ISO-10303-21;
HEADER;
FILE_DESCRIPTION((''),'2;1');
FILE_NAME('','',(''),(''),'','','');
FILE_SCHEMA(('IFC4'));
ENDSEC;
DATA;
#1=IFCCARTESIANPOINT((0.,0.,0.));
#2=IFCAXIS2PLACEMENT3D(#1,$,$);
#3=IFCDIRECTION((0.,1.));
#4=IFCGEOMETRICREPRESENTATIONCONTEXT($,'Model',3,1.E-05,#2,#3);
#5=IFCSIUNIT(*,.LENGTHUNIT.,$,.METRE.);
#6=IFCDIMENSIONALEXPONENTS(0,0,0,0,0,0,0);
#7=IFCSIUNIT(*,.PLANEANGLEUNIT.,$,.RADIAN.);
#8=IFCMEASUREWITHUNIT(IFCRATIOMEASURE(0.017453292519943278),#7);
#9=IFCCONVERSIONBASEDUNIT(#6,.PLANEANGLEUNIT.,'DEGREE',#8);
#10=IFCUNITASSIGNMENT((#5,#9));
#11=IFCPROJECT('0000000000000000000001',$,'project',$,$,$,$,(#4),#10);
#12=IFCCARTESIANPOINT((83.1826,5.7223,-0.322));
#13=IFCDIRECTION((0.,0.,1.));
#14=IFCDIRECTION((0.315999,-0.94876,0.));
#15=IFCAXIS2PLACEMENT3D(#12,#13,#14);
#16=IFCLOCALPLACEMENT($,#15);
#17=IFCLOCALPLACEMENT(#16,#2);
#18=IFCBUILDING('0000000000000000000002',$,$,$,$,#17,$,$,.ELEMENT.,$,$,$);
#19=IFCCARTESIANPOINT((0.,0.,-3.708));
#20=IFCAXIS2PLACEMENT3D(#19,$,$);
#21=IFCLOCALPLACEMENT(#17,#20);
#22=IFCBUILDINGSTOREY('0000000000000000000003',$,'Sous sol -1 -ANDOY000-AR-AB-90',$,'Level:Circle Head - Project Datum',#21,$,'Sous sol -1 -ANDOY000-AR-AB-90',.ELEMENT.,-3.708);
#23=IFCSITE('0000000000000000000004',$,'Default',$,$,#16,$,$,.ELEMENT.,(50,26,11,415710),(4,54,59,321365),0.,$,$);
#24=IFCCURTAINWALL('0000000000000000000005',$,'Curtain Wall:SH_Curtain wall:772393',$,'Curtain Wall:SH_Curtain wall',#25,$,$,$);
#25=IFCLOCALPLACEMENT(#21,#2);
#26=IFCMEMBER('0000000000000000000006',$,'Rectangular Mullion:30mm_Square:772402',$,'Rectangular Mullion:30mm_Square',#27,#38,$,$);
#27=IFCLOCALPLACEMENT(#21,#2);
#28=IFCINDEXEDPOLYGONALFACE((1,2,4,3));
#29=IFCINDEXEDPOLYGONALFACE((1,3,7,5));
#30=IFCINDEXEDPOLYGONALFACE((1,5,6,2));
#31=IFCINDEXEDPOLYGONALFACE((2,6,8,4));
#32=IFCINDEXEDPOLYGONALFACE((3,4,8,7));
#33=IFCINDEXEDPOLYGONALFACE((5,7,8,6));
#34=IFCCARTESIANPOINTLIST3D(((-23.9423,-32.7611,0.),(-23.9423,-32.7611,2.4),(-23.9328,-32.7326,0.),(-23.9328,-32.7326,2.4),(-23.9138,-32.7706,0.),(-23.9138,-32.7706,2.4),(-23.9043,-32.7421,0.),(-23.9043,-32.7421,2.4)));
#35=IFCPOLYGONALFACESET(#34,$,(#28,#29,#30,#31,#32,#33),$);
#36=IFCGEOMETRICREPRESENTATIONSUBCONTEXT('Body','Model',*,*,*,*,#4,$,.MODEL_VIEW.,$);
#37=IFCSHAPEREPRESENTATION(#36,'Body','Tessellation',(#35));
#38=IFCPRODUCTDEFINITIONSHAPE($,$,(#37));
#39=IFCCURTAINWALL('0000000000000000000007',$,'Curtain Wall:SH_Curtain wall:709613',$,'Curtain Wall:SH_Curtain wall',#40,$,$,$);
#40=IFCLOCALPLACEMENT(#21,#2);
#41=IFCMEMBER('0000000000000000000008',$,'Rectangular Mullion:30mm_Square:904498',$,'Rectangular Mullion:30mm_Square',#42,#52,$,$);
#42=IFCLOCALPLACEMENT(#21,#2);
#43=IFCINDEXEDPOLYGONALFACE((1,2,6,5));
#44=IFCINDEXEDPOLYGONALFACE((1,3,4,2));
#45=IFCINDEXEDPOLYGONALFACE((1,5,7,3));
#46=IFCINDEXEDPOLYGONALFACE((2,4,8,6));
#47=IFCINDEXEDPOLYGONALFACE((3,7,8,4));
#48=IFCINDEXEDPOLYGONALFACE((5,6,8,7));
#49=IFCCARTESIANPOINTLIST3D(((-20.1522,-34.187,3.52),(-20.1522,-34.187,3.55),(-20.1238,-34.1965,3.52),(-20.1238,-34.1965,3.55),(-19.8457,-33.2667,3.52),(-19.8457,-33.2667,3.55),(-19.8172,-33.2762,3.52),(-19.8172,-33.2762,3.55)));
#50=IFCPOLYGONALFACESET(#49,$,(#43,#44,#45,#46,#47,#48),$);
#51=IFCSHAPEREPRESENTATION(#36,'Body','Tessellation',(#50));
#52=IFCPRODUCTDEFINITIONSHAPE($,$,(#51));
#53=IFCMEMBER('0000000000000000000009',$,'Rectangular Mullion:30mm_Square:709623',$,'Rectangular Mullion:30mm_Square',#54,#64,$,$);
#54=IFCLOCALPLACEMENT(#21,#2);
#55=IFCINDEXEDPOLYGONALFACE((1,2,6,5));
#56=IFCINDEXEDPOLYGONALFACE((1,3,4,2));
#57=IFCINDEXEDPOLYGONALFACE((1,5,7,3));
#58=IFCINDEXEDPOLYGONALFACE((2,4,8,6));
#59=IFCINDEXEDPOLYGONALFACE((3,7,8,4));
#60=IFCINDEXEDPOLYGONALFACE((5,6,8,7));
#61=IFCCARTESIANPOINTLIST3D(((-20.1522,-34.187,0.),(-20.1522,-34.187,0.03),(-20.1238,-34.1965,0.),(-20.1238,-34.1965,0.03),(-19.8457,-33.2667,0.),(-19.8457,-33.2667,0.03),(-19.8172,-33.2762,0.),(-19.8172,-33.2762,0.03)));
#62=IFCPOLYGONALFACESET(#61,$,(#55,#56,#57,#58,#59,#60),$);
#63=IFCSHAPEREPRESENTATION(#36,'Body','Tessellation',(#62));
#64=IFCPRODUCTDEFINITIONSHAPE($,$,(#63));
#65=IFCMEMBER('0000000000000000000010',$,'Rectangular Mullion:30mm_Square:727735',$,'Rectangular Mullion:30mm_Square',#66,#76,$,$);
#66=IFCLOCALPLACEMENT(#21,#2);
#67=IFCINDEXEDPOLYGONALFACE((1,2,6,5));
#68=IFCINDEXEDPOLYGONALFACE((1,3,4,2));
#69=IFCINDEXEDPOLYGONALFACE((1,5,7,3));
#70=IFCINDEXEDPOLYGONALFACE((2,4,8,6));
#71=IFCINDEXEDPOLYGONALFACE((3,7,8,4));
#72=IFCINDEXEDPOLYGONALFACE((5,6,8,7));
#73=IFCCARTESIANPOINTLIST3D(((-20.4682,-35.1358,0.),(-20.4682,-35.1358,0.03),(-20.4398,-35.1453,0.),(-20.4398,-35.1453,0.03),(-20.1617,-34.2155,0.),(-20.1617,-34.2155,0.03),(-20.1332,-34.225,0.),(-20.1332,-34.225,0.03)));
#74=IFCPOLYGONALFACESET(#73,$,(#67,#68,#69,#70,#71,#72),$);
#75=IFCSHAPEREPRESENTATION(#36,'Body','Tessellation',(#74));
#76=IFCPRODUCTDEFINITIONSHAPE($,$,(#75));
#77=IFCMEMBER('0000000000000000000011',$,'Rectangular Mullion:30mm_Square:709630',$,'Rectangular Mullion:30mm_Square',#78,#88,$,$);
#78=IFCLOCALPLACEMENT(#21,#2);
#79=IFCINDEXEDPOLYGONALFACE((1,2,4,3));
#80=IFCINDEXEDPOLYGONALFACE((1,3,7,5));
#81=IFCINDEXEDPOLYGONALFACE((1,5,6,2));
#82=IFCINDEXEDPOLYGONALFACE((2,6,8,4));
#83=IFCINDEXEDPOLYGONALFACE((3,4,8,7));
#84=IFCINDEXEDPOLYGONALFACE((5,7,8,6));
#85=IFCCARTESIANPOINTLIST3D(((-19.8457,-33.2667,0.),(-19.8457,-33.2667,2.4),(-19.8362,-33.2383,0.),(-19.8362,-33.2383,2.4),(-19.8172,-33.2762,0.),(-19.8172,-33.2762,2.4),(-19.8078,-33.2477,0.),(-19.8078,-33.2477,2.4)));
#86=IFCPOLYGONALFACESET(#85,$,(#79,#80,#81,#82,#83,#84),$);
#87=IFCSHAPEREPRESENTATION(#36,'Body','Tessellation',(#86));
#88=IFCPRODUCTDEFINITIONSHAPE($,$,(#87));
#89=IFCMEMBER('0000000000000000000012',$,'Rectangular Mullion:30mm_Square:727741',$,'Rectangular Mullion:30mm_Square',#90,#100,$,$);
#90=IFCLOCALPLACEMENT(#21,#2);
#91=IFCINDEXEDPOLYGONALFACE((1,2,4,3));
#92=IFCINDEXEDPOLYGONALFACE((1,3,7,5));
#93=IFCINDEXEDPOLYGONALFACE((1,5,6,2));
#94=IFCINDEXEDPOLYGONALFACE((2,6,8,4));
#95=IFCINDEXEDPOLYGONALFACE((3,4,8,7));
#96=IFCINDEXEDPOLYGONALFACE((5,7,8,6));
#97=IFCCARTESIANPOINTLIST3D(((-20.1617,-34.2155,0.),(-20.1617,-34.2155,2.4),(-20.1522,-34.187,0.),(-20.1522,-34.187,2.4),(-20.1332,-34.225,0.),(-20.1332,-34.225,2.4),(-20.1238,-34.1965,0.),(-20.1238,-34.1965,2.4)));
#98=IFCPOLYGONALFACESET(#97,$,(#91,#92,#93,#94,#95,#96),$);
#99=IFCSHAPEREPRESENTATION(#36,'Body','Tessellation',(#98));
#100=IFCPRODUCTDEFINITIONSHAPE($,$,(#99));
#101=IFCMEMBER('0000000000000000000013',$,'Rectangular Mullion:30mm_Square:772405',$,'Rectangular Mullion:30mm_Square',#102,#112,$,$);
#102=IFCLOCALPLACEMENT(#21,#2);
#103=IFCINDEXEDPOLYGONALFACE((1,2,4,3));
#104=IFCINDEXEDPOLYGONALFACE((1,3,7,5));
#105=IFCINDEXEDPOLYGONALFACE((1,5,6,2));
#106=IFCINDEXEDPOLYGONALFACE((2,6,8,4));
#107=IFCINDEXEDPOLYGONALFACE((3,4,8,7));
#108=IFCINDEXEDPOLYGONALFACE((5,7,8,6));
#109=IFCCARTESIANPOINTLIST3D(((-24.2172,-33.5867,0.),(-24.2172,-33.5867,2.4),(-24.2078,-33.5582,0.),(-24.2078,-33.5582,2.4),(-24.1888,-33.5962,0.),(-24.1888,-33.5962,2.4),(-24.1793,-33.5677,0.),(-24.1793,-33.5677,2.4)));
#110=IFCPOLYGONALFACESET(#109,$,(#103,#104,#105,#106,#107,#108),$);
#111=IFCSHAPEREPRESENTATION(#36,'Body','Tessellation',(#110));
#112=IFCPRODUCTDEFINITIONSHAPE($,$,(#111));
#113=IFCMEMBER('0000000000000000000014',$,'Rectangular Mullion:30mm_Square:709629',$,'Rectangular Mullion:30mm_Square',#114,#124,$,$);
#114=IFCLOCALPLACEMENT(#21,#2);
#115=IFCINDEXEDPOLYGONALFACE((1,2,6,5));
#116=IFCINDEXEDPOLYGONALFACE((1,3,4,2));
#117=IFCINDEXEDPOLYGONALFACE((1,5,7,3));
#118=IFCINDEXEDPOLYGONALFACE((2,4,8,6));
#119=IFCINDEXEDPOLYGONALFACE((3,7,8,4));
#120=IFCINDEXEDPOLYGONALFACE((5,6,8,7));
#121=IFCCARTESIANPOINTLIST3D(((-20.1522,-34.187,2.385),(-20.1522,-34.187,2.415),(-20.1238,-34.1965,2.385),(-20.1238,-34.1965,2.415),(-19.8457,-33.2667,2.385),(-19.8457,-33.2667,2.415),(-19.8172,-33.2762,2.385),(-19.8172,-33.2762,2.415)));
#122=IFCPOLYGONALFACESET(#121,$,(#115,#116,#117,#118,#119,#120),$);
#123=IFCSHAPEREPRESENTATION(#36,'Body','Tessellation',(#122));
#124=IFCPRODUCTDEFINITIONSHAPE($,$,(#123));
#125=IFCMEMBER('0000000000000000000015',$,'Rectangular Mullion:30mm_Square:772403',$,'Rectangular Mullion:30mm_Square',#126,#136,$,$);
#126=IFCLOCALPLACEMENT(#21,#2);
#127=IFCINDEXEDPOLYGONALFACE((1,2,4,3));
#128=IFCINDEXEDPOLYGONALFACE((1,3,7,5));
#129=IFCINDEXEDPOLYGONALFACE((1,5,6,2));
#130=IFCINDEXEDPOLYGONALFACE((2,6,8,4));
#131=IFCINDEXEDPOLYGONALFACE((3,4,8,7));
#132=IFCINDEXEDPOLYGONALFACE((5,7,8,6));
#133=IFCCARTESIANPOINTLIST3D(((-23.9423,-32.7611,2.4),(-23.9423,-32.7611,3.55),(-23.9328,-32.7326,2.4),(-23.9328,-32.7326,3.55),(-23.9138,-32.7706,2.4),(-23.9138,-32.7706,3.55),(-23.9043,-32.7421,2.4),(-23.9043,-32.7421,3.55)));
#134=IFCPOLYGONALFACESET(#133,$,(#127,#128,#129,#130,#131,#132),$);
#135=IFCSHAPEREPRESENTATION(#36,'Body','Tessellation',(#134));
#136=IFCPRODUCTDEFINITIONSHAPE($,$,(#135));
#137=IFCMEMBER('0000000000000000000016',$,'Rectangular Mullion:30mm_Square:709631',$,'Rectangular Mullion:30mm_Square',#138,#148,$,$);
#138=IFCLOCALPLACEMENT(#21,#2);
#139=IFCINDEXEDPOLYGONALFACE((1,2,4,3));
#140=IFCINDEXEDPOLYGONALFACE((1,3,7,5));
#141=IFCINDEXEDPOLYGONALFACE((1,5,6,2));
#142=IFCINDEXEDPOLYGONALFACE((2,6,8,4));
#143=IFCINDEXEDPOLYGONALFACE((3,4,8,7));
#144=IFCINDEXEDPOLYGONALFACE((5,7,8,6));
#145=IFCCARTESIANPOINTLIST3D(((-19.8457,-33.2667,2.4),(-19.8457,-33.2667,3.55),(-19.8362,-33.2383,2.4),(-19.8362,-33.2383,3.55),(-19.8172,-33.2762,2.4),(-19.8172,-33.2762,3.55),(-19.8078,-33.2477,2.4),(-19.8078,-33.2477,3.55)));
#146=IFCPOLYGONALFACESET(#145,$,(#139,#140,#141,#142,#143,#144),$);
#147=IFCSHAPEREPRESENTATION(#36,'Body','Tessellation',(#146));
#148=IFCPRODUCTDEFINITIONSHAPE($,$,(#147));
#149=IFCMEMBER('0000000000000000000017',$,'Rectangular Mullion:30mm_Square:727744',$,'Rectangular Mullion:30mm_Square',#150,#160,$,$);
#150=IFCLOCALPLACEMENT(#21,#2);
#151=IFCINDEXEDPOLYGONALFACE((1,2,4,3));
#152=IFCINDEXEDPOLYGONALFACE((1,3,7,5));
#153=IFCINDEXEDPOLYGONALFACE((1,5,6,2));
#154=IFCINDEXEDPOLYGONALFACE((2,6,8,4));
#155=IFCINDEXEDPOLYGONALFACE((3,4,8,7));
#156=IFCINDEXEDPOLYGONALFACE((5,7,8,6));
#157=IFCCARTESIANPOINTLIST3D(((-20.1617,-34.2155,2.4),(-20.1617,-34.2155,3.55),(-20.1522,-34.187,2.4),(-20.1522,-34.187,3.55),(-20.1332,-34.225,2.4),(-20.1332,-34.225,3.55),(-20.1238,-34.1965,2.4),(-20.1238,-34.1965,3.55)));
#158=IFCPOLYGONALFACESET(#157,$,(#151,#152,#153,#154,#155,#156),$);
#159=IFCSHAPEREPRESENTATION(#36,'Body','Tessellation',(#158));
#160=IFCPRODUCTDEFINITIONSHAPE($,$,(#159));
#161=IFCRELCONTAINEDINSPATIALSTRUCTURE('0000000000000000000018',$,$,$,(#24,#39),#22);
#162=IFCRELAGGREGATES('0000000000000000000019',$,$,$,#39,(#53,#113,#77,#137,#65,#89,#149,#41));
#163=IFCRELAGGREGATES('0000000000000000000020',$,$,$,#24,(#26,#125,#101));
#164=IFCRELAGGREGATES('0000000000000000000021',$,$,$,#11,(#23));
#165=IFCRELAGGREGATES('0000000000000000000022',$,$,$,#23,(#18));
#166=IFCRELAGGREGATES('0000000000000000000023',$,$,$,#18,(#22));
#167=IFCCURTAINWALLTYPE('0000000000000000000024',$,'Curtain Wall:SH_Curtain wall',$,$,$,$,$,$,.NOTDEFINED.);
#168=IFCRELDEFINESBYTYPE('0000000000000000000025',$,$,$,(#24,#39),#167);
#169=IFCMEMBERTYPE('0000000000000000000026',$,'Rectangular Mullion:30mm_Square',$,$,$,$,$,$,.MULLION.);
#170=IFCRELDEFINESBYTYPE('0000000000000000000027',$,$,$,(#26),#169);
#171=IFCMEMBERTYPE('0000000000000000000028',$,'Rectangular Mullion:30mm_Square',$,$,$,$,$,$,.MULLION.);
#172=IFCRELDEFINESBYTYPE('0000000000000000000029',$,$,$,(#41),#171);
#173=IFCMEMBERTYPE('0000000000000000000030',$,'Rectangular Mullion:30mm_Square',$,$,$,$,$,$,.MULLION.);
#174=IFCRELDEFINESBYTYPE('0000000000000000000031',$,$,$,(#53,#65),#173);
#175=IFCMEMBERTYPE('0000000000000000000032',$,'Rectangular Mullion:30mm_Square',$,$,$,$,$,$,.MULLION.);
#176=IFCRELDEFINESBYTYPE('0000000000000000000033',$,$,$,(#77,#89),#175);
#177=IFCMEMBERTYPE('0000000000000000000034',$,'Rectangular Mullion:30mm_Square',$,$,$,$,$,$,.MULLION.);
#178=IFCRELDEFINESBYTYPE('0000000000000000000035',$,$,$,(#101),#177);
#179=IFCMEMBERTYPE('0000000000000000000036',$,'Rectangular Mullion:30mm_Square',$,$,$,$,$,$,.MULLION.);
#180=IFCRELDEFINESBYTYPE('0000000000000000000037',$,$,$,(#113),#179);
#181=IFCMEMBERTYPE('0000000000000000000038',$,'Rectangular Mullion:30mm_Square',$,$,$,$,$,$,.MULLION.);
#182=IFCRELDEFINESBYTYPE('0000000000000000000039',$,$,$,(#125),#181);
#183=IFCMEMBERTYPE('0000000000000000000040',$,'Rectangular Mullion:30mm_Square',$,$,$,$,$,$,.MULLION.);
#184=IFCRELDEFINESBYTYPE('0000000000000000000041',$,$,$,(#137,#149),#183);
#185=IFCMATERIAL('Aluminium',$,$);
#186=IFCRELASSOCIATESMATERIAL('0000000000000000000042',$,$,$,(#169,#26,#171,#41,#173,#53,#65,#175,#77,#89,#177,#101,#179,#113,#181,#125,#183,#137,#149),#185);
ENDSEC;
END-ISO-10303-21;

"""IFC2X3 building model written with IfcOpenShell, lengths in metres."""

from ifc_helpers import new_model, entity, si_unit, converted_unit, direction, frame, origin, origin_2d_with_axis, place, context, subcontext, project, spatial, rectangle, extrude, source, transform, mapped, material, type_object, type_shapes, element, aggregate, save


model = new_model("IFC2X3")

# Units and contexts
model_context = context("Model", 3, precision=1e-05, world=origin(), true_north=direction((0.0, 1.0)))
body_context = subcontext(model_context, "Body", "Model", "MODEL_VIEW")
ifc_project = project(units=[si_unit("LENGTHUNIT", "METRE"), converted_unit("PLANEANGLEUNIT", "DEGREE", entity("IfcRatioMeasure", 0.017453292519943278), si_unit("PLANEANGLEUNIT", "RADIAN"), dimensions=[0, 0, 0, 0, 0, 0, 0])], contexts=[model_context])

# Site, building, storey
site_placement = place(None, frame((83.1826, 5.7223, -0.322), z_axis=(0.0, 0.0, 1.0), x_axis=(0.315999, -0.94876, 0.0)))
site = spatial("IfcSite", under=ifc_project, at=site_placement, Name="Default", CompositionType="ELEMENT", RefLatitude=(50, 26, 11, 415710), RefLongitude=(4, 54, 59, 321365), RefElevation=0.0)
building_placement = place(site_placement, origin())
building = spatial("IfcBuilding", under=site, at=building_placement, CompositionType="ELEMENT")
storey_placement = place(building_placement, frame((0.0, 0.0, -3.708)))
storey = spatial("IfcBuildingStorey", under=building, at=storey_placement, Name="Sous sol -1 -ANDOY000-AR-AB-90", ObjectType="Level:Circle Head - Project Datum", LongName="Sous sol -1 -ANDOY000-AR-AB-90", CompositionType="ELEMENT", Elevation=-3.708)

# Curtain wall, member
curtain_wall_type = type_object("IfcCurtainWallType", Name="Curtain Wall:SH_Curtain wall", PredefinedType="NOTDEFINED")
curtain_wall_1_placement = place(storey_placement, frame((0.0, 0.0, 3.708)))
curtain_wall_1 = element("IfcCurtainWall", 1, at=curtain_wall_1_placement, inside=storey, type_object=curtain_wall_type, Name="Curtain Wall:SH_Curtain wall:772393", ObjectType="Curtain Wall:SH_Curtain wall")
ifc_material_1 = material(Name="Aluminium")
member_type_1 = type_object("IfcMemberType", Name="Rectangular Mullion:30mm_Square", PredefinedType="MULLION", material=ifc_material_1)
shared_shape_1 = source(origin(), body_context, "Body", "SweptSolid", [
    extrude(rectangle(XDim=0.03, YDim=0.03, at=origin_2d_with_axis()), frame((-0.015, 0.0, -2.4), z_axis=(0.0, 0.0, 1.0), x_axis=(0.0, -1.0, 0.0)), (0.0, 0.0, 1.0), 2.4),
])
type_shapes(member_type_1, [shared_shape_1])
member_1_placement = place(curtain_wall_1_placement, frame((-23.9185, -32.7373, -3.708), z_axis=(0.0, 0.0, -1.0), x_axis=(0.316, 0.948759, 0.0)))
member_1 = element("IfcMember", 2, at=member_1_placement, type_object=member_type_1, material=ifc_material_1, Name="Rectangular Mullion:30mm_Square:772402", ObjectType="Rectangular Mullion:30mm_Square", context=body_context, shape_type="MappedRepresentation", body=[
    mapped(shared_shape_1, transform((0.0, 0.0, 0.0), scale=1.0)),
])

# Curtain wall, members
curtain_wall_2_placement = place(storey_placement, frame((0.0, 0.0, 3.708)))
curtain_wall_2 = element("IfcCurtainWall", 3, at=curtain_wall_2_placement, inside=storey, type_object=curtain_wall_type, Name="Curtain Wall:SH_Curtain wall:709613", ObjectType="Curtain Wall:SH_Curtain wall")
member_type_2 = type_object("IfcMemberType", Name="Rectangular Mullion:30mm_Square", PredefinedType="MULLION", material=ifc_material_1)
shared_shape_2 = source(origin(), body_context, "Body", "SweptSolid", [
    extrude(rectangle(XDim=0.03, YDim=0.03, at=origin_2d_with_axis()), frame((-0.015, 0.0, -0.97), z_axis=(0.0, 0.0, 1.0), x_axis=(0.0, -1.0, 0.0)), (0.0, 0.0, 1.0), 0.97),
])
type_shapes(member_type_2, [shared_shape_2])
member_2_placement = place(curtain_wall_2_placement, frame((-20.138, -34.1918, -0.158), z_axis=(-0.316, -0.948759, 0.0), x_axis=(0.0, 0.0, 1.0)))
member_2 = element("IfcMember", 4, at=member_2_placement, type_object=member_type_2, material=ifc_material_1, Name="Rectangular Mullion:30mm_Square:904498", ObjectType="Rectangular Mullion:30mm_Square", context=body_context, shape_type="MappedRepresentation", body=[
    mapped(shared_shape_2, transform((0.0, 0.0, 0.0), scale=1.0)),
])
member_type_3 = type_object("IfcMemberType", Name="Rectangular Mullion:30mm_Square", PredefinedType="MULLION", material=ifc_material_1)
shared_shape_3 = source(origin(), body_context, "Body", "SweptSolid", [
    extrude(rectangle(XDim=0.03, YDim=0.03, at=origin_2d_with_axis()), frame((-0.015, 0.0, -0.97), z_axis=(0.0, 0.0, 1.0), x_axis=(0.0, -1.0, 0.0)), (0.0, 0.0, 1.0), 0.97),
])
type_shapes(member_type_3, [shared_shape_3])
member_3_placement = place(curtain_wall_2_placement, frame((-19.8315, -33.2715, -3.708), z_axis=(0.316, 0.948759, 0.0), x_axis=(0.0, 0.0, -1.0)))
member_3 = element("IfcMember", 5, at=member_3_placement, type_object=member_type_3, material=ifc_material_1, Name="Rectangular Mullion:30mm_Square:709623", ObjectType="Rectangular Mullion:30mm_Square", context=body_context, shape_type="MappedRepresentation", body=[
    mapped(shared_shape_3, transform((0.0, 0.0, 0.0), scale=1.0)),
])
member_4_placement = place(curtain_wall_2_placement, frame((-20.1475, -34.2202, -3.708), z_axis=(0.316, 0.948759, 0.0), x_axis=(0.0, 0.0, -1.0)))
member_4 = element("IfcMember", 6, at=member_4_placement, type_object=member_type_3, material=ifc_material_1, Name="Rectangular Mullion:30mm_Square:727735", ObjectType="Rectangular Mullion:30mm_Square", context=body_context, shape_type="MappedRepresentation", body=[
    mapped(shared_shape_3, transform((0.0, 0.0, 0.0), scale=1.0)),
])
member_type_4 = type_object("IfcMemberType", Name="Rectangular Mullion:30mm_Square", PredefinedType="MULLION", material=ifc_material_1)
shared_shape_4 = source(origin(), body_context, "Body", "SweptSolid", [
    extrude(rectangle(XDim=0.03, YDim=0.03, at=origin_2d_with_axis()), frame((0.0, 0.0, -2.4), z_axis=(0.0, 0.0, 1.0), x_axis=(0.0, -1.0, 0.0)), (0.0, 0.0, 1.0), 2.4),
])
type_shapes(member_type_4, [shared_shape_4])
member_5_placement = place(curtain_wall_2_placement, frame((-19.8267, -33.2572, -3.708), z_axis=(0.0, 0.0, -1.0), x_axis=(-0.316, -0.948759, 0.0)))
member_5 = element("IfcMember", 7, at=member_5_placement, type_object=member_type_4, material=ifc_material_1, Name="Rectangular Mullion:30mm_Square:709630", ObjectType="Rectangular Mullion:30mm_Square", context=body_context, shape_type="MappedRepresentation", body=[
    mapped(shared_shape_4, transform((0.0, 0.0, 0.0), scale=1.0)),
])
member_6_placement = place(curtain_wall_2_placement, frame((-20.1427, -34.206, -3.708), z_axis=(0.0, 0.0, -1.0), x_axis=(-0.316, -0.948759, 0.0)))
member_6 = element("IfcMember", 8, at=member_6_placement, type_object=member_type_4, material=ifc_material_1, Name="Rectangular Mullion:30mm_Square:727741", ObjectType="Rectangular Mullion:30mm_Square", context=body_context, shape_type="MappedRepresentation", body=[
    mapped(shared_shape_4, transform((0.0, 0.0, 0.0), scale=1.0)),
])

# Members
member_type_5 = type_object("IfcMemberType", Name="Rectangular Mullion:30mm_Square", PredefinedType="MULLION", material=ifc_material_1)
shared_shape_5 = source(origin(), body_context, "Body", "SweptSolid", [
    extrude(rectangle(XDim=0.03, YDim=0.03, at=origin_2d_with_axis()), frame((-0.015, 0.0, -2.4), z_axis=(0.0, 0.0, 1.0), x_axis=(0.0, -1.0, 0.0)), (0.0, 0.0, 1.0), 2.4),
])
type_shapes(member_type_5, [shared_shape_5])
member_7_placement = place(curtain_wall_1_placement, frame((-24.203, -33.5914, -1.308), z_axis=(0.0, 0.0, 1.0), x_axis=(-0.316, -0.948759, 0.0)))
member_7 = element("IfcMember", 9, at=member_7_placement, type_object=member_type_5, material=ifc_material_1, Name="Rectangular Mullion:30mm_Square:772405", ObjectType="Rectangular Mullion:30mm_Square", context=body_context, shape_type="MappedRepresentation", body=[
    mapped(shared_shape_5, transform((0.0, 0.0, 0.0), scale=1.0)),
])
member_type_6 = type_object("IfcMemberType", Name="Rectangular Mullion:30mm_Square", PredefinedType="MULLION", material=ifc_material_1)
shared_shape_6 = source(origin(), body_context, "Body", "SweptSolid", [
    extrude(rectangle(XDim=0.03, YDim=0.03, at=origin_2d_with_axis()), frame((0.0, 0.0, -0.97), z_axis=(0.0, 0.0, 1.0), x_axis=(0.0, -1.0, 0.0)), (0.0, 0.0, 1.0), 0.97),
])
type_shapes(member_type_6, [shared_shape_6])
member_8_placement = place(curtain_wall_2_placement, frame((-20.138, -34.1918, -1.308), z_axis=(-0.316, -0.948759, 0.0), x_axis=(0.0, 0.0, 1.0)))
member_8 = element("IfcMember", 10, at=member_8_placement, type_object=member_type_6, material=ifc_material_1, Name="Rectangular Mullion:30mm_Square:709629", ObjectType="Rectangular Mullion:30mm_Square", context=body_context, shape_type="MappedRepresentation", body=[
    mapped(shared_shape_6, transform((0.0, 0.0, 0.0), scale=1.0)),
])
member_type_7 = type_object("IfcMemberType", Name="Rectangular Mullion:30mm_Square", PredefinedType="MULLION", material=ifc_material_1)
shared_shape_7 = source(origin(), body_context, "Body", "SweptSolid", [
    extrude(rectangle(XDim=0.03, YDim=0.03, at=origin_2d_with_axis()), frame((-0.015, 0.0, -1.15), z_axis=(0.0, 0.0, 1.0), x_axis=(0.0, -1.0, 0.0)), (0.0, 0.0, 1.0), 1.15),
])
type_shapes(member_type_7, [shared_shape_7])
member_9_placement = place(curtain_wall_1_placement, frame((-23.9185, -32.7373, -1.308), z_axis=(0.0, 0.0, -1.0), x_axis=(0.316, 0.948759, 0.0)))
member_9 = element("IfcMember", 11, at=member_9_placement, type_object=member_type_7, material=ifc_material_1, Name="Rectangular Mullion:30mm_Square:772403", ObjectType="Rectangular Mullion:30mm_Square", context=body_context, shape_type="MappedRepresentation", body=[
    mapped(shared_shape_7, transform((0.0, 0.0, 0.0), scale=1.0)),
])
member_type_8 = type_object("IfcMemberType", Name="Rectangular Mullion:30mm_Square", PredefinedType="MULLION", material=ifc_material_1)
shared_shape_8 = source(origin(), body_context, "Body", "SweptSolid", [
    extrude(rectangle(XDim=0.03, YDim=0.03, at=origin_2d_with_axis()), frame((0.0, 0.0, -1.15), z_axis=(0.0, 0.0, 1.0), x_axis=(0.0, -1.0, 0.0)), (0.0, 0.0, 1.0), 1.15),
])
type_shapes(member_type_8, [shared_shape_8])
member_10_placement = place(curtain_wall_2_placement, frame((-19.8267, -33.2572, -1.308), z_axis=(0.0, 0.0, -1.0), x_axis=(-0.316, -0.948759, 0.0)))
member_10 = element("IfcMember", 12, at=member_10_placement, type_object=member_type_8, material=ifc_material_1, Name="Rectangular Mullion:30mm_Square:709631", ObjectType="Rectangular Mullion:30mm_Square", context=body_context, shape_type="MappedRepresentation", body=[
    mapped(shared_shape_8, transform((0.0, 0.0, 0.0), scale=1.0)),
])
member_11_placement = place(curtain_wall_2_placement, frame((-20.1427, -34.206, -1.308), z_axis=(0.0, 0.0, -1.0), x_axis=(-0.316, -0.948759, 0.0)))
member_11 = element("IfcMember", 13, at=member_11_placement, type_object=member_type_8, material=ifc_material_1, Name="Rectangular Mullion:30mm_Square:727744", ObjectType="Rectangular Mullion:30mm_Square", context=body_context, shape_type="MappedRepresentation", body=[
    mapped(shared_shape_8, transform((0.0, 0.0, 0.0), scale=1.0)),
])

aggregate(curtain_wall_2, [member_3, member_8, member_5, member_10, member_4, member_6, member_11, member_2])
aggregate(curtain_wall_1, [member_1, member_9, member_7])

save(model, "model.ifc")
